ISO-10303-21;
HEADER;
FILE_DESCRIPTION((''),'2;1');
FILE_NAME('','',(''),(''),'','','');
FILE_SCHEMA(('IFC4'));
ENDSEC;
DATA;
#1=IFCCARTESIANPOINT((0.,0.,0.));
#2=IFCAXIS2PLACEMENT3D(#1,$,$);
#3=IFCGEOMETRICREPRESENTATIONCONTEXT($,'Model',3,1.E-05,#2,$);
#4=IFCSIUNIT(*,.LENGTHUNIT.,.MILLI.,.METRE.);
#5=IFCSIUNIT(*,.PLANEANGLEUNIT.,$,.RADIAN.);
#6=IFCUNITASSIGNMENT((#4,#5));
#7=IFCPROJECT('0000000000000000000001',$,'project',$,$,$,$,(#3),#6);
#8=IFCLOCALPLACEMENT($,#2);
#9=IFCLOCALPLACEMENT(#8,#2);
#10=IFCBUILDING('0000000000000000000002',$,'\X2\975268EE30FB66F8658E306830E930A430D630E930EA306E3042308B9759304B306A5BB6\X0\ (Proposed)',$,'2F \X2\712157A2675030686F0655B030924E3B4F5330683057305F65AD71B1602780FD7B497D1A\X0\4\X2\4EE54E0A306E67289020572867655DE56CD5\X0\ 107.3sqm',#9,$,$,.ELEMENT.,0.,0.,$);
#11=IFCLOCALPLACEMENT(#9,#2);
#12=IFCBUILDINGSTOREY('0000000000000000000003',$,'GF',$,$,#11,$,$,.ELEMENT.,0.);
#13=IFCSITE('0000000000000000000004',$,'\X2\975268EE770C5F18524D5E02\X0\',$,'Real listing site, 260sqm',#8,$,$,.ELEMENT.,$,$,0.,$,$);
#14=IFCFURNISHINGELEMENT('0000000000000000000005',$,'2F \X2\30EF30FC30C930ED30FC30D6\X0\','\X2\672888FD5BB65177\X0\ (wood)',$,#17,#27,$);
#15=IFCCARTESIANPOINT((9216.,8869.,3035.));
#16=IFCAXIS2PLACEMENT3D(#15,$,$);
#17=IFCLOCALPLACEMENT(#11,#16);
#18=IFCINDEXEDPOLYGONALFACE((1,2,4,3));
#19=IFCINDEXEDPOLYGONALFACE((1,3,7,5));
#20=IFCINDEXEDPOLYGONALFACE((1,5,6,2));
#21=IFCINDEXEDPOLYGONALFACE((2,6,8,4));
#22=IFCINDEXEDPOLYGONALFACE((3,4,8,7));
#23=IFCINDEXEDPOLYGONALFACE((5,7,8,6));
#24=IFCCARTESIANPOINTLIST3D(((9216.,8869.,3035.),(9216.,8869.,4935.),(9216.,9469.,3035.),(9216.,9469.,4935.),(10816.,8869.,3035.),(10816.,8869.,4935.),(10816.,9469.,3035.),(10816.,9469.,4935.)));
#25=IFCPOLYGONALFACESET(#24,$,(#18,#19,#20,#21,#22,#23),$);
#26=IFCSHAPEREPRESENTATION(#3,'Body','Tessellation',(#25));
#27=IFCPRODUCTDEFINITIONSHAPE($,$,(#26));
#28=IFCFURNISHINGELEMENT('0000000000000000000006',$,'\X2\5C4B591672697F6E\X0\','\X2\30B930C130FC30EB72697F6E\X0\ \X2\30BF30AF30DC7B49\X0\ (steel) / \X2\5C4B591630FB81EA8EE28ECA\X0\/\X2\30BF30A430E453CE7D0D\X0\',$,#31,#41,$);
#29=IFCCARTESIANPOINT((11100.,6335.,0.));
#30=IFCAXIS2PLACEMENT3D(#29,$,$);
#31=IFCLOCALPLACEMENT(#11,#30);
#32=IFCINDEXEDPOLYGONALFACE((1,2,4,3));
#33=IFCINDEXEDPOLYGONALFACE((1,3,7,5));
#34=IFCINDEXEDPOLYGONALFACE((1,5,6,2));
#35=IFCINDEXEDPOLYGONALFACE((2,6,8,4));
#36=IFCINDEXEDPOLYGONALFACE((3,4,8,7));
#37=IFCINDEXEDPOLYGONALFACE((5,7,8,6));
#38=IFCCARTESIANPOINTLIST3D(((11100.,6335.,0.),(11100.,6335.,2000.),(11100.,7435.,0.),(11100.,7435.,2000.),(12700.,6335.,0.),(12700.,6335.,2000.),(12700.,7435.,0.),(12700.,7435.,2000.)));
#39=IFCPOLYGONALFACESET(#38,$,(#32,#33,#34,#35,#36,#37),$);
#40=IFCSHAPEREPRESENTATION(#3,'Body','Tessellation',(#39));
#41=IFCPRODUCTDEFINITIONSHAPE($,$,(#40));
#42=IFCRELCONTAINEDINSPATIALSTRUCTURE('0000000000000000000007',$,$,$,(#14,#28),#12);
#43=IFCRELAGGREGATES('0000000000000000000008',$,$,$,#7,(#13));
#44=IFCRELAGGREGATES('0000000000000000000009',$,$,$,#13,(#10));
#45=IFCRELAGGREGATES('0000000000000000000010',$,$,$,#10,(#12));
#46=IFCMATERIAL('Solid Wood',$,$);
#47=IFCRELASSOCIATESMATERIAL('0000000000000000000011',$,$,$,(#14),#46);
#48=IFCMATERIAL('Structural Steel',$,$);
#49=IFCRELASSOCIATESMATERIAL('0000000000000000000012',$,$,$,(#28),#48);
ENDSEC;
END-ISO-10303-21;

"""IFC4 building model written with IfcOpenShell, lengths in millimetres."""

from ifc_helpers import new_model, si_unit, frame, frame_2d, origin, place, context, project, spatial, rectangle, extrude, material, element, save


model = new_model("IFC4")

# Units and contexts
model_context = context("Model", 3, precision=1e-05, world=origin())
ifc_project = project(units=[si_unit("LENGTHUNIT", "METRE", prefix="MILLI"), si_unit("PLANEANGLEUNIT", "RADIAN")], contexts=[model_context])

# Site, building, storey
site_placement = place(None, origin())
site = spatial("IfcSite", under=ifc_project, at=site_placement, Name="青森県弘前市", ObjectType="Real listing site, 260sqm", CompositionType="ELEMENT", RefElevation=0.0)
building_placement = place(site_placement, origin())
building = spatial("IfcBuilding", under=site, at=building_placement, Name="青森・書斎とライブラリのある静かな家 (Proposed)", ObjectType="2F 無垢材と漆喰を主体とした断熱性能等級4以上の木造在来工法 107.3sqm", CompositionType="ELEMENT", ElevationOfRefHeight=0.0, ElevationOfTerrain=0.0)
storey_placement = place(building_placement, origin())
storey = spatial("IfcBuildingStorey", under=building, at=storey_placement, Name="GF", CompositionType="ELEMENT", Elevation=0.0)

# Shared definitions
ifc_material_1 = material(Name="Solid Wood")

# Shared definitions
ifc_material_2 = material(Name="Structural Steel")

# Furnishing elements
furnishing_1_placement = place(storey_placement, frame((9216.0, 8869.0, 3035.0)))
element("IfcFurnishingElement", 1, at=furnishing_1_placement, inside=storey, material=ifc_material_1, Name="2F ワードローブ", Description="木製家具 (wood)", context=model_context, shape_type="SweptSolid", body=[
    extrude(rectangle(XDim=1600.0, YDim=600.0, at=frame_2d((800.0, 300.0))), frame((9216.0, 8869.0, 3035.0)), (0.0, 0.0, 1.0), 1900.0),
])
furnishing_2_placement = place(storey_placement, frame((11100.0, 6335.0, 0.0)))
element("IfcFurnishingElement", 2, at=furnishing_2_placement, inside=storey, material=ifc_material_2, Name="屋外物置", Description="スチール物置 タクボ等 (steel) / 屋外・自転車/タイヤ収納", context=model_context, shape_type="SweptSolid", body=[
    extrude(rectangle(XDim=1600.0, YDim=1100.0, at=frame_2d((800.0, 550.0))), frame((11100.0, 6335.0, 0.0)), (0.0, 0.0, 1.0), 2000.0),
])

save(model, "model.ifc")
